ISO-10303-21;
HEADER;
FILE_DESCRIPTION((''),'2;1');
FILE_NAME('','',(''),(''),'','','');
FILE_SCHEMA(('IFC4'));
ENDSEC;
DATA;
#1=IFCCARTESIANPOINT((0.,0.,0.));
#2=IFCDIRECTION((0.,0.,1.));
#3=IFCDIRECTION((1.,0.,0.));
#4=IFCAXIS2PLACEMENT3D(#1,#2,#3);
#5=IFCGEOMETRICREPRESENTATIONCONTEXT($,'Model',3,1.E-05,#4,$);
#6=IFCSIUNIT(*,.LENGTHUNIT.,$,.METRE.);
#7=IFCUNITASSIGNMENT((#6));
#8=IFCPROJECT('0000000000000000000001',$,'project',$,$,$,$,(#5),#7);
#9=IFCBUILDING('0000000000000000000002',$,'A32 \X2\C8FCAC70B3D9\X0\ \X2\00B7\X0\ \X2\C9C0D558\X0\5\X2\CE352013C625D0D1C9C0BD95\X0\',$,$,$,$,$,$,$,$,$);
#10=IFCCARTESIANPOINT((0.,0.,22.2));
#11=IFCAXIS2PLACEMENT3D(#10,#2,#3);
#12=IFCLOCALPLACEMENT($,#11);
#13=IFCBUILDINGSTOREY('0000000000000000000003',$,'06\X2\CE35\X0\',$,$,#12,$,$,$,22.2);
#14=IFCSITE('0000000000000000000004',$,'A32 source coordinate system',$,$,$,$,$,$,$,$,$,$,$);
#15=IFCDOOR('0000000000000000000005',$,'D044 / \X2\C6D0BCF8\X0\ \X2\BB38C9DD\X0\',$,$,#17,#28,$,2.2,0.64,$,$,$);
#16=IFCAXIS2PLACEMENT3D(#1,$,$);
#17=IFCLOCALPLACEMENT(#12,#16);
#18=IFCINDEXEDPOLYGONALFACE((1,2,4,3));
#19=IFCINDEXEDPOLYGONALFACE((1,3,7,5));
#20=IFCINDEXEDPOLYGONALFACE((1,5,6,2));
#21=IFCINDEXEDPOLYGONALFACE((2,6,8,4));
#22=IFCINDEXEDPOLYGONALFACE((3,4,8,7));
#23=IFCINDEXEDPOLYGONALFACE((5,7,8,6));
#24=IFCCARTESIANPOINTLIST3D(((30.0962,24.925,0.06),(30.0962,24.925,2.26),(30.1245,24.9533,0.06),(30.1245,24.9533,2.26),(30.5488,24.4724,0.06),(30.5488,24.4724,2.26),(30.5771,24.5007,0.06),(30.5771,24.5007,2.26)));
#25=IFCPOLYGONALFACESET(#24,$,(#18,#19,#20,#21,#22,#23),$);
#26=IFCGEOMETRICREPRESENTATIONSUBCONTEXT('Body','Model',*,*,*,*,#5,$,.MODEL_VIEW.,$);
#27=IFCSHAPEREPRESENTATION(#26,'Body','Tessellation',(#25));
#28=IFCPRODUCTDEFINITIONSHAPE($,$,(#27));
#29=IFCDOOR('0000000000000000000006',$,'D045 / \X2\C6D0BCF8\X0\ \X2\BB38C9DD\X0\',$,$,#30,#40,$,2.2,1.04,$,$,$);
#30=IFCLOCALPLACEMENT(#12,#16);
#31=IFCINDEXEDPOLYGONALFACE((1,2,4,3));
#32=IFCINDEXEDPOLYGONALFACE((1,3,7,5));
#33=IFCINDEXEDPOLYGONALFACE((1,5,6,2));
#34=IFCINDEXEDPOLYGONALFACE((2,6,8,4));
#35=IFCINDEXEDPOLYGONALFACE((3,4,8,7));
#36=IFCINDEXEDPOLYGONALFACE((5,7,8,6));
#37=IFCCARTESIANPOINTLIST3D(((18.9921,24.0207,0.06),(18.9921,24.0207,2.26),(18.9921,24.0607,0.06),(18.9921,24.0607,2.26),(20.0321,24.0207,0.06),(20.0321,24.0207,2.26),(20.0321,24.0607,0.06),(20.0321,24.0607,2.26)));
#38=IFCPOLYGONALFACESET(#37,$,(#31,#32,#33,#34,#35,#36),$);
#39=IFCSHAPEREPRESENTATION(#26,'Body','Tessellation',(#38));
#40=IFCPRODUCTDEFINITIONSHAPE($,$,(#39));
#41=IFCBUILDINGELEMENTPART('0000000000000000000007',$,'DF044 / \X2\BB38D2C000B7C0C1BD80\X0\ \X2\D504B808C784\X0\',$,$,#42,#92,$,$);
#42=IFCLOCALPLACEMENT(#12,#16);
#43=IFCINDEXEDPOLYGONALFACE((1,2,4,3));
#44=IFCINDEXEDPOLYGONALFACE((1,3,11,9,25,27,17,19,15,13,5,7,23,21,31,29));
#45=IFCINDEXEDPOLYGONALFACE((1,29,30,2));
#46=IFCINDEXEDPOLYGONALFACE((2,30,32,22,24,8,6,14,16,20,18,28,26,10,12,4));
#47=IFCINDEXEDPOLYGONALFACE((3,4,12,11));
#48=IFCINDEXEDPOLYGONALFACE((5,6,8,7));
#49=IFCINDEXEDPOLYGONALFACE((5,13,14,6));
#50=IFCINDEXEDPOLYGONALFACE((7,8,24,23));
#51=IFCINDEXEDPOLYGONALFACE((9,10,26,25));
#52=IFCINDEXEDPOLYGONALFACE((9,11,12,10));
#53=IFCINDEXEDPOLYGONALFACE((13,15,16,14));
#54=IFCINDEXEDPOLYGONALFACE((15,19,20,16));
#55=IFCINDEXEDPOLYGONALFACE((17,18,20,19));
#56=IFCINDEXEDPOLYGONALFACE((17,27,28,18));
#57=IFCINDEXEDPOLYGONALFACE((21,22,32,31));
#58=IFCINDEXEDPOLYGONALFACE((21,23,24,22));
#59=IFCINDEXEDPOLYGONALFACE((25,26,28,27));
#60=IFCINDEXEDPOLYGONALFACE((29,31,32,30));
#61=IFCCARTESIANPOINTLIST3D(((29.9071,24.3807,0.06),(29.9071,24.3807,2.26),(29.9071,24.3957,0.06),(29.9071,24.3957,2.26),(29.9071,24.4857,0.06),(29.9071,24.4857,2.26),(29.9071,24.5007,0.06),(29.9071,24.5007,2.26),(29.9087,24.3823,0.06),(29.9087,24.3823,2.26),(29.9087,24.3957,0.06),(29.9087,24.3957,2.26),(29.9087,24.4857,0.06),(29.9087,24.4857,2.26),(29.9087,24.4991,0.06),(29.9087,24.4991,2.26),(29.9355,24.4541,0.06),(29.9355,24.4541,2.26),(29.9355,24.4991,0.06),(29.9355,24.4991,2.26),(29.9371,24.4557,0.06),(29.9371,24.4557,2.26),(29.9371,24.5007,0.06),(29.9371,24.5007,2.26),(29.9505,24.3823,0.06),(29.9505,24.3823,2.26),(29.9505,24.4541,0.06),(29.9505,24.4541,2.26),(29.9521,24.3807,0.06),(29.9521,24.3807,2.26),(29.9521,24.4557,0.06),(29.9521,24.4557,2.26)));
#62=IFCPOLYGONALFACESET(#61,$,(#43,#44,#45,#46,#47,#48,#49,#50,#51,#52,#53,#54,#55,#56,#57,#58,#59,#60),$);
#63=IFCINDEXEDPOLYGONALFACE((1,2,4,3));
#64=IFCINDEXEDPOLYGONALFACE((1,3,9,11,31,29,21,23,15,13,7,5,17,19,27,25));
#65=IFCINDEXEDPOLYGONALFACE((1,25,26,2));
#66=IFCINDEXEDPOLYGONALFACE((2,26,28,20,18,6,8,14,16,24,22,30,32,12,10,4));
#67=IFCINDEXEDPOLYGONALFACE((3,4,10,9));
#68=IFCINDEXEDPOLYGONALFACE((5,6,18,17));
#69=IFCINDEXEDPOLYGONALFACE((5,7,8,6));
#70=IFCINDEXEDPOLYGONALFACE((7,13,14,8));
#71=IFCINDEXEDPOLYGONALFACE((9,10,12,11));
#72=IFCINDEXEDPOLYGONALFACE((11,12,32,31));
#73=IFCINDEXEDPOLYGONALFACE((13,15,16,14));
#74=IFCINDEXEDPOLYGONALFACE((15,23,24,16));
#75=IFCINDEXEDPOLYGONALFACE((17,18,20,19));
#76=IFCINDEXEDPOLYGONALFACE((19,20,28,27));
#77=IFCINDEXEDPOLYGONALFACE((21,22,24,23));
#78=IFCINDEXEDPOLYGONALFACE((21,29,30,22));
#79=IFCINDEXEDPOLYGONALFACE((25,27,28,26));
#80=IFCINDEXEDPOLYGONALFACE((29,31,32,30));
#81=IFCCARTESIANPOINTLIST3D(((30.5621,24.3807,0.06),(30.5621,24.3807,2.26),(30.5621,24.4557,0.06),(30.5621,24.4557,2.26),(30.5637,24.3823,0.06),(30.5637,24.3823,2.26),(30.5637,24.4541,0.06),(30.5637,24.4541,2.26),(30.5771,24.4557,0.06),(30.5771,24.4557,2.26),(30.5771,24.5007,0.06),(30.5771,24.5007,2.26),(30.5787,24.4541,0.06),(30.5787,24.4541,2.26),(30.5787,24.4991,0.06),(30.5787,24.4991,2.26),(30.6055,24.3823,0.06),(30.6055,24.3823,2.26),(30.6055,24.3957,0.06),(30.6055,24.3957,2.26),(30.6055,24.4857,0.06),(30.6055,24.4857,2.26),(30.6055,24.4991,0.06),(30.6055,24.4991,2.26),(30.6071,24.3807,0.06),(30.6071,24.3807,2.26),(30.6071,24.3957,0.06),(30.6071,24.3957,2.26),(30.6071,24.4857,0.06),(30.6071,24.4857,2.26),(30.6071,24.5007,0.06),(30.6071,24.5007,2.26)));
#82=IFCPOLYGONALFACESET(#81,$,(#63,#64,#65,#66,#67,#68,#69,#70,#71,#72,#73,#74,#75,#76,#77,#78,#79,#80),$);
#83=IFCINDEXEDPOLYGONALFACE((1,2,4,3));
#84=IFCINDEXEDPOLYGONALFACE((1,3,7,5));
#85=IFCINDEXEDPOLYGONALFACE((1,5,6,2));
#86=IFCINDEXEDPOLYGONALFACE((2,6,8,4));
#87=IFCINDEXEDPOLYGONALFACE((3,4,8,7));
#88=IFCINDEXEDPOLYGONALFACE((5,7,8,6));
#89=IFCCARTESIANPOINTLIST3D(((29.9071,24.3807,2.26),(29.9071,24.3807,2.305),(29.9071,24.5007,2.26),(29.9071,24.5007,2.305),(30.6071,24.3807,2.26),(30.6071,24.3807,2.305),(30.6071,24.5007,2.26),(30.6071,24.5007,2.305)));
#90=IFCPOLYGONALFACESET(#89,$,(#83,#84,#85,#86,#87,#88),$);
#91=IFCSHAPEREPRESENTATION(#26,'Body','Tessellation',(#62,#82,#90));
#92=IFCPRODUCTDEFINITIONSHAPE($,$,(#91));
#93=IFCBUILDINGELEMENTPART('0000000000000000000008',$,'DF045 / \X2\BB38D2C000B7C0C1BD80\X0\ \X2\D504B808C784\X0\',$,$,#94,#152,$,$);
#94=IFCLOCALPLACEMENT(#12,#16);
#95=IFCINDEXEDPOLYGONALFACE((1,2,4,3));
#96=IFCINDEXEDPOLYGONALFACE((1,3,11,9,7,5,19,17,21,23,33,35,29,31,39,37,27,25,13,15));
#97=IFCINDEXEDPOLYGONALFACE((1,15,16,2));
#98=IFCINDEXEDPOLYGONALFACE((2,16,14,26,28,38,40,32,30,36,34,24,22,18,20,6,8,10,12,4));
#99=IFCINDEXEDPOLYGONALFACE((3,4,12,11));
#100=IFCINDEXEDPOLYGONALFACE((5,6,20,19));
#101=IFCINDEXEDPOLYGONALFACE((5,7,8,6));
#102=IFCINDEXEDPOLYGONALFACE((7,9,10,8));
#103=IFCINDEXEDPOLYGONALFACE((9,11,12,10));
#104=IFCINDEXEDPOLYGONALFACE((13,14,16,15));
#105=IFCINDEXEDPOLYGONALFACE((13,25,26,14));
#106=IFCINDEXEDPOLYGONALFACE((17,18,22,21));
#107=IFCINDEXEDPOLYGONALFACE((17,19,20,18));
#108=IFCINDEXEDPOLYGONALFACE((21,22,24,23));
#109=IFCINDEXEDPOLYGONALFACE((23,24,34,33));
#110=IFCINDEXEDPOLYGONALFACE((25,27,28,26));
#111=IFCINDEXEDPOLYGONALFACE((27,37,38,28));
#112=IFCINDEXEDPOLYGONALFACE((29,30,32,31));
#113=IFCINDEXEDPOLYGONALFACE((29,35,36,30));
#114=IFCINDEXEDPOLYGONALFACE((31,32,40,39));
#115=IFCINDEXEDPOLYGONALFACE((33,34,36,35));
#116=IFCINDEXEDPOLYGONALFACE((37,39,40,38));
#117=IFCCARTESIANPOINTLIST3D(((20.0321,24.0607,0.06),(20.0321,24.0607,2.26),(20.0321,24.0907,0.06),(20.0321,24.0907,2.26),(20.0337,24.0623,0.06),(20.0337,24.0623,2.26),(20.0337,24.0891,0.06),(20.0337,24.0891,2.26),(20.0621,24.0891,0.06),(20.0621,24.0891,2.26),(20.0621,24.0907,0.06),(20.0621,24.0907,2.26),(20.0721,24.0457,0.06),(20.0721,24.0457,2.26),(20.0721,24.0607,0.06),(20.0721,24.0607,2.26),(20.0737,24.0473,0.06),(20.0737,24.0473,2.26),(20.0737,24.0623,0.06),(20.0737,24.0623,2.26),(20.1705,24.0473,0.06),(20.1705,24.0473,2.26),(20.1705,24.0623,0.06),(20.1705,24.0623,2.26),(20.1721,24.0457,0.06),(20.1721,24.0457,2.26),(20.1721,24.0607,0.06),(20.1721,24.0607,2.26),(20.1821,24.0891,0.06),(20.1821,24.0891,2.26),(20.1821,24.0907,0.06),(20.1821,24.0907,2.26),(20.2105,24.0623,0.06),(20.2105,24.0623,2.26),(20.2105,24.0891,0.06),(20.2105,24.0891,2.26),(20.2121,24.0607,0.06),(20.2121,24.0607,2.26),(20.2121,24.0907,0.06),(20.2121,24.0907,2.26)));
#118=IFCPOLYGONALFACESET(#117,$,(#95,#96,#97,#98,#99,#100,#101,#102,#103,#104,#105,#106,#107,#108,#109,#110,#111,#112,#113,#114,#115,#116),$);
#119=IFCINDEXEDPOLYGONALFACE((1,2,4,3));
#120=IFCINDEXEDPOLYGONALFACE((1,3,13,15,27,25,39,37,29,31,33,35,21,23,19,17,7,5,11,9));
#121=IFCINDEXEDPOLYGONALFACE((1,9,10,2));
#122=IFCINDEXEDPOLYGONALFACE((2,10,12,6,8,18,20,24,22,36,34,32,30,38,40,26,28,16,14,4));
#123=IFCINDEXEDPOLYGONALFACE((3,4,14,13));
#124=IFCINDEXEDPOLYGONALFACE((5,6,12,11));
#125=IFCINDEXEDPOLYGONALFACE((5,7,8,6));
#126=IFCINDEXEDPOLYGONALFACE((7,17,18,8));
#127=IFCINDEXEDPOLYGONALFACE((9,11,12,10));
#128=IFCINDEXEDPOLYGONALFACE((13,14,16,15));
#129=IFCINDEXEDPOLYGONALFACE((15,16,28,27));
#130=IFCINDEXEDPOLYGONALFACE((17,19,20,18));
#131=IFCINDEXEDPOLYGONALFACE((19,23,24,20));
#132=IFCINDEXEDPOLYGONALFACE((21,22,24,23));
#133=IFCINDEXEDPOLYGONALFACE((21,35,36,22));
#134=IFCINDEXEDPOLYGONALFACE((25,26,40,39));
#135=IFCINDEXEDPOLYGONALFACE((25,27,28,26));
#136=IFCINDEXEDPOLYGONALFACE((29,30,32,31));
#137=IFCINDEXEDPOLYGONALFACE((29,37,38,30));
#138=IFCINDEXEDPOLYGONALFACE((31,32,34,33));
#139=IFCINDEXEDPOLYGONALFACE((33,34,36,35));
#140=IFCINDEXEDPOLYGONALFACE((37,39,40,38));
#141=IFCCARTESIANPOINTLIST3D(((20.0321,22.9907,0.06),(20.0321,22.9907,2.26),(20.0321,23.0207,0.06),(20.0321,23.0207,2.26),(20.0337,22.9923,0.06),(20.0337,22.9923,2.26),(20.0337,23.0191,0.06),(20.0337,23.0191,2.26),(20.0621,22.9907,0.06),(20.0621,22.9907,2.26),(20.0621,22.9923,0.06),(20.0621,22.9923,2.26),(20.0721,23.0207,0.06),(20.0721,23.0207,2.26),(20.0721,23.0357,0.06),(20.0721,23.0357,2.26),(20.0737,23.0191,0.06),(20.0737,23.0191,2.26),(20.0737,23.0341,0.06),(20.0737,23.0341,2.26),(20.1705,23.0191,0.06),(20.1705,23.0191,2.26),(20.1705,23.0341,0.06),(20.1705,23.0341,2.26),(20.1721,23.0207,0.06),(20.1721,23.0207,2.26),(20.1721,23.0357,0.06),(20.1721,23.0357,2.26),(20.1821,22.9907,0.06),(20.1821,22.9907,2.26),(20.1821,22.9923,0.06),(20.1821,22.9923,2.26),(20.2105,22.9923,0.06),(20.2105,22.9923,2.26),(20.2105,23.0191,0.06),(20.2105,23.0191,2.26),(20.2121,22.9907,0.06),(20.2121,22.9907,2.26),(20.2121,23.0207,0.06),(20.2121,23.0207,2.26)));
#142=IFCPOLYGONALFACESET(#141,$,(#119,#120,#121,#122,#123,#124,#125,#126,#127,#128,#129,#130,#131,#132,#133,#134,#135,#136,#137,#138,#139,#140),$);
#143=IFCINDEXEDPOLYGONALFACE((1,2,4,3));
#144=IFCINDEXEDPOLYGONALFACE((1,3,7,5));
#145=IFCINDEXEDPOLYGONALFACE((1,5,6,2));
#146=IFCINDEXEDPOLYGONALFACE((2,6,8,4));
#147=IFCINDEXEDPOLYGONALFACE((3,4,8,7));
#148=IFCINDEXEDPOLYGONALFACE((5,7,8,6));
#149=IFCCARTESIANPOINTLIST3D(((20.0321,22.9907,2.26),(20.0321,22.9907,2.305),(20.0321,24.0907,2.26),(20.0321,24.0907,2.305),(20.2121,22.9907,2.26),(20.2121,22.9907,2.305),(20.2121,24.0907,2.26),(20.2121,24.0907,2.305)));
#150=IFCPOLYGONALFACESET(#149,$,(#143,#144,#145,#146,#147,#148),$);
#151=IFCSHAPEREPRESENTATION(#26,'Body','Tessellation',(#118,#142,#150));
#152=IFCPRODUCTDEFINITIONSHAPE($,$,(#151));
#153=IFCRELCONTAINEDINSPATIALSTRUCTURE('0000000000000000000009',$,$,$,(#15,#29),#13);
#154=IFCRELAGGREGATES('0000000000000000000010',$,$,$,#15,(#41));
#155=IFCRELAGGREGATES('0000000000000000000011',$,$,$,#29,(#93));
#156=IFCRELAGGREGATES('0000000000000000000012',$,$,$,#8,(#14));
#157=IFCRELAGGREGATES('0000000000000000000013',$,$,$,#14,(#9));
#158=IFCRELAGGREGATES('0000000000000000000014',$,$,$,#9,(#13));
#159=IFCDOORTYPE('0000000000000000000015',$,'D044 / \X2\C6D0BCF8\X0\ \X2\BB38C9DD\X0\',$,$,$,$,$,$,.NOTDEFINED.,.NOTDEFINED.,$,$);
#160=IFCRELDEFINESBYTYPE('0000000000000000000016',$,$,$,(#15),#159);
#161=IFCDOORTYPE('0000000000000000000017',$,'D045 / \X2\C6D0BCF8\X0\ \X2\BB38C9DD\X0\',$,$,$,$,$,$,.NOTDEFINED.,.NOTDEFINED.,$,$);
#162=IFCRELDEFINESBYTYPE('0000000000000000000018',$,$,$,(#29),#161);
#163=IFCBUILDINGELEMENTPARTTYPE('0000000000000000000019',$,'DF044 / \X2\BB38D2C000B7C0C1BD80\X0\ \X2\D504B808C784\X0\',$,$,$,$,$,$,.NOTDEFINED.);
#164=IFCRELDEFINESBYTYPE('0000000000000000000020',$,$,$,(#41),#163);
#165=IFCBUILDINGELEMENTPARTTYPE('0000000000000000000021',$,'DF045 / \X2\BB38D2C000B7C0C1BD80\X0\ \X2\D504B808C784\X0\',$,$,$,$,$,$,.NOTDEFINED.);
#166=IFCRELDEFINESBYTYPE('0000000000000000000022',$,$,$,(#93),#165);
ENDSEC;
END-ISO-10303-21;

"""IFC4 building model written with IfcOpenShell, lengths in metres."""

from ifc_helpers import new_model, si_unit, frame, origin, origin_with_axes, place, context, subcontext, project, spatial, polyline, outline, extrude, source, transform, mapped, type_object, type_shapes, element, aggregate, save


model = new_model("IFC4")

# Units and contexts
model_context = context("Model", 3, precision=1e-05, world=origin_with_axes())
body_context = subcontext(model_context, "Body", "Model", "MODEL_VIEW")
ifc_project = project(units=[si_unit("LENGTHUNIT", "METRE")], contexts=[model_context])

# Site, building, storey
storey_placement = place(None, frame((0.0, 0.0, 22.2), z_axis=(0.0, 0.0, 1.0), x_axis=(1.0, 0.0, 0.0)))
site = spatial("IfcSite", under=ifc_project, Name="A32 source coordinate system")
building = spatial("IfcBuilding", under=site, Name="A32 주거동 · 지하5층–옥탑지붕")
storey = spatial("IfcBuildingStorey", under=building, at=storey_placement, Name="06층", Elevation=22.2)

# Doors
door_type_1 = type_object("IfcDoorType", Name="D044 / 원본 문짝", OperationType="NOTDEFINED", PredefinedType="NOTDEFINED")
shared_shape_1 = source(origin(), body_context, "Body", "SweptSolid", [
    extrude(outline(polyline([(30.5771, 24.5007), (30.5488, 24.4724), (30.0962, 24.925), (30.1245, 24.9533), (30.5771, 24.5007)])), frame((0.0, 0.0, 0.06)), (0.0, 0.0, 1.0), 2.2),
])
type_shapes(door_type_1, [shared_shape_1])
door_1_placement = place(storey_placement, origin_with_axes())
door_1 = element("IfcDoor", 1, at=door_1_placement, inside=storey, type_object=door_type_1, Name="D044 / 원본 문짝", OverallHeight=2.2, OverallWidth=0.64, context=body_context, shape_type="MappedRepresentation", body=[
    mapped(shared_shape_1, transform((0.0, 0.0, 0.0), scale=1.0)),
])
door_type_2 = type_object("IfcDoorType", Name="D045 / 원본 문짝", OperationType="NOTDEFINED", PredefinedType="NOTDEFINED")
shared_shape_2 = source(origin(), body_context, "Body", "SweptSolid", [
    extrude(outline(polyline([(20.0321, 24.0607), (20.0321, 24.0207), (18.9921, 24.0207), (18.9921, 24.0607), (20.0321, 24.0607)])), frame((0.0, 0.0, 0.06)), (0.0, 0.0, 1.0), 2.2),
])
type_shapes(door_type_2, [shared_shape_2])
door_2_placement = place(storey_placement, origin_with_axes())
door_2 = element("IfcDoor", 2, at=door_2_placement, inside=storey, type_object=door_type_2, Name="D045 / 원본 문짝", OverallHeight=2.2, OverallWidth=1.04, context=body_context, shape_type="MappedRepresentation", body=[
    mapped(shared_shape_2, transform((0.0, 0.0, 0.0), scale=1.0)),
])

# Building element parts
building_element_part_type_1 = type_object("IfcBuildingElementPartType", Name="DF044 / 문틀·상부 프레임", PredefinedType="NOTDEFINED")
shared_shape_3 = source(origin(), body_context, "Body", "SweptSolid", [
    extrude(outline(polyline([(29.9071, 24.4857), (29.9071, 24.5007), (29.9371, 24.5007), (29.9371, 24.4557), (29.9521, 24.4557), (29.9521, 24.3807), (29.9071, 24.3807), (29.9071, 24.3957), (29.9087, 24.3957), (29.9087, 24.3823), (29.9505, 24.3823), (29.9505, 24.4541), (29.9355, 24.4541), (29.9355, 24.4991), (29.9087, 24.4991), (29.9087, 24.4857), (29.9071, 24.4857)])), frame((0.0, 0.0, 0.06)), (0.0, 0.0, 1.0), 2.2),
    extrude(outline(polyline([(30.6055, 24.4991), (30.5787, 24.4991), (30.5787, 24.4541), (30.5637, 24.4541), (30.5637, 24.3823), (30.6055, 24.3823), (30.6055, 24.3957), (30.6071, 24.3957), (30.6071, 24.3807), (30.5621, 24.3807), (30.5621, 24.4557), (30.5771, 24.4557), (30.5771, 24.5007), (30.6071, 24.5007), (30.6071, 24.4857), (30.6055, 24.4857), (30.6055, 24.4991)])), frame((0.0, 0.0, 0.06)), (0.0, 0.0, 1.0), 2.2),
    extrude(outline(polyline([(29.9071, 24.3807), (29.9071, 24.5007), (30.6071, 24.5007), (30.6071, 24.3807), (29.9071, 24.3807)])), frame((0.0, 0.0, 2.26)), (0.0, 0.0, 1.0), 0.045),
])
type_shapes(building_element_part_type_1, [shared_shape_3])
building_element_part_1_placement = place(door_1_placement, origin_with_axes())
building_element_part_1 = element("IfcBuildingElementPart", 3, at=building_element_part_1_placement, type_object=building_element_part_type_1, Name="DF044 / 문틀·상부 프레임", context=body_context, shape_type="MappedRepresentation", body=[
    mapped(shared_shape_3, transform((0.0, 0.0, 0.0), scale=1.0)),
])
aggregate(door_1, [building_element_part_1])
building_element_part_type_2 = type_object("IfcBuildingElementPartType", Name="DF045 / 문틀·상부 프레임", PredefinedType="NOTDEFINED")
shared_shape_4 = source(origin(), body_context, "Body", "SweptSolid", [
    extrude(outline(polyline([(20.0337, 24.0891), (20.0337, 24.0623), (20.0737, 24.0623), (20.0737, 24.0473), (20.1705, 24.0473), (20.1705, 24.0623), (20.2105, 24.0623), (20.2105, 24.0891), (20.1821, 24.0891), (20.1821, 24.0907), (20.2121, 24.0907), (20.2121, 24.0607), (20.1721, 24.0607), (20.1721, 24.0457), (20.0721, 24.0457), (20.0721, 24.0607), (20.0321, 24.0607), (20.0321, 24.0907), (20.0621, 24.0907), (20.0621, 24.0891), (20.0337, 24.0891)])), frame((0.0, 0.0, 0.06)), (0.0, 0.0, 1.0), 2.2),
    extrude(outline(polyline([(20.0621, 22.9907), (20.0321, 22.9907), (20.0321, 23.0207), (20.0721, 23.0207), (20.0721, 23.0357), (20.1721, 23.0357), (20.1721, 23.0207), (20.2121, 23.0207), (20.2121, 22.9907), (20.1821, 22.9907), (20.1821, 22.9923), (20.2105, 22.9923), (20.2105, 23.0191), (20.1705, 23.0191), (20.1705, 23.0341), (20.0737, 23.0341), (20.0737, 23.0191), (20.0337, 23.0191), (20.0337, 22.9923), (20.0621, 22.9923), (20.0621, 22.9907)])), frame((0.0, 0.0, 0.06)), (0.0, 0.0, 1.0), 2.2),
    extrude(outline(polyline([(20.0321, 22.9907), (20.0321, 24.0907), (20.2121, 24.0907), (20.2121, 22.9907), (20.0321, 22.9907)])), frame((0.0, 0.0, 2.26)), (0.0, 0.0, 1.0), 0.045),
])
type_shapes(building_element_part_type_2, [shared_shape_4])
building_element_part_2_placement = place(door_2_placement, origin_with_axes())
building_element_part_2 = element("IfcBuildingElementPart", 4, at=building_element_part_2_placement, type_object=building_element_part_type_2, Name="DF045 / 문틀·상부 프레임", context=body_context, shape_type="MappedRepresentation", body=[
    mapped(shared_shape_4, transform((0.0, 0.0, 0.0), scale=1.0)),
])
aggregate(door_2, [building_element_part_2])

save(model, "model.ifc")
